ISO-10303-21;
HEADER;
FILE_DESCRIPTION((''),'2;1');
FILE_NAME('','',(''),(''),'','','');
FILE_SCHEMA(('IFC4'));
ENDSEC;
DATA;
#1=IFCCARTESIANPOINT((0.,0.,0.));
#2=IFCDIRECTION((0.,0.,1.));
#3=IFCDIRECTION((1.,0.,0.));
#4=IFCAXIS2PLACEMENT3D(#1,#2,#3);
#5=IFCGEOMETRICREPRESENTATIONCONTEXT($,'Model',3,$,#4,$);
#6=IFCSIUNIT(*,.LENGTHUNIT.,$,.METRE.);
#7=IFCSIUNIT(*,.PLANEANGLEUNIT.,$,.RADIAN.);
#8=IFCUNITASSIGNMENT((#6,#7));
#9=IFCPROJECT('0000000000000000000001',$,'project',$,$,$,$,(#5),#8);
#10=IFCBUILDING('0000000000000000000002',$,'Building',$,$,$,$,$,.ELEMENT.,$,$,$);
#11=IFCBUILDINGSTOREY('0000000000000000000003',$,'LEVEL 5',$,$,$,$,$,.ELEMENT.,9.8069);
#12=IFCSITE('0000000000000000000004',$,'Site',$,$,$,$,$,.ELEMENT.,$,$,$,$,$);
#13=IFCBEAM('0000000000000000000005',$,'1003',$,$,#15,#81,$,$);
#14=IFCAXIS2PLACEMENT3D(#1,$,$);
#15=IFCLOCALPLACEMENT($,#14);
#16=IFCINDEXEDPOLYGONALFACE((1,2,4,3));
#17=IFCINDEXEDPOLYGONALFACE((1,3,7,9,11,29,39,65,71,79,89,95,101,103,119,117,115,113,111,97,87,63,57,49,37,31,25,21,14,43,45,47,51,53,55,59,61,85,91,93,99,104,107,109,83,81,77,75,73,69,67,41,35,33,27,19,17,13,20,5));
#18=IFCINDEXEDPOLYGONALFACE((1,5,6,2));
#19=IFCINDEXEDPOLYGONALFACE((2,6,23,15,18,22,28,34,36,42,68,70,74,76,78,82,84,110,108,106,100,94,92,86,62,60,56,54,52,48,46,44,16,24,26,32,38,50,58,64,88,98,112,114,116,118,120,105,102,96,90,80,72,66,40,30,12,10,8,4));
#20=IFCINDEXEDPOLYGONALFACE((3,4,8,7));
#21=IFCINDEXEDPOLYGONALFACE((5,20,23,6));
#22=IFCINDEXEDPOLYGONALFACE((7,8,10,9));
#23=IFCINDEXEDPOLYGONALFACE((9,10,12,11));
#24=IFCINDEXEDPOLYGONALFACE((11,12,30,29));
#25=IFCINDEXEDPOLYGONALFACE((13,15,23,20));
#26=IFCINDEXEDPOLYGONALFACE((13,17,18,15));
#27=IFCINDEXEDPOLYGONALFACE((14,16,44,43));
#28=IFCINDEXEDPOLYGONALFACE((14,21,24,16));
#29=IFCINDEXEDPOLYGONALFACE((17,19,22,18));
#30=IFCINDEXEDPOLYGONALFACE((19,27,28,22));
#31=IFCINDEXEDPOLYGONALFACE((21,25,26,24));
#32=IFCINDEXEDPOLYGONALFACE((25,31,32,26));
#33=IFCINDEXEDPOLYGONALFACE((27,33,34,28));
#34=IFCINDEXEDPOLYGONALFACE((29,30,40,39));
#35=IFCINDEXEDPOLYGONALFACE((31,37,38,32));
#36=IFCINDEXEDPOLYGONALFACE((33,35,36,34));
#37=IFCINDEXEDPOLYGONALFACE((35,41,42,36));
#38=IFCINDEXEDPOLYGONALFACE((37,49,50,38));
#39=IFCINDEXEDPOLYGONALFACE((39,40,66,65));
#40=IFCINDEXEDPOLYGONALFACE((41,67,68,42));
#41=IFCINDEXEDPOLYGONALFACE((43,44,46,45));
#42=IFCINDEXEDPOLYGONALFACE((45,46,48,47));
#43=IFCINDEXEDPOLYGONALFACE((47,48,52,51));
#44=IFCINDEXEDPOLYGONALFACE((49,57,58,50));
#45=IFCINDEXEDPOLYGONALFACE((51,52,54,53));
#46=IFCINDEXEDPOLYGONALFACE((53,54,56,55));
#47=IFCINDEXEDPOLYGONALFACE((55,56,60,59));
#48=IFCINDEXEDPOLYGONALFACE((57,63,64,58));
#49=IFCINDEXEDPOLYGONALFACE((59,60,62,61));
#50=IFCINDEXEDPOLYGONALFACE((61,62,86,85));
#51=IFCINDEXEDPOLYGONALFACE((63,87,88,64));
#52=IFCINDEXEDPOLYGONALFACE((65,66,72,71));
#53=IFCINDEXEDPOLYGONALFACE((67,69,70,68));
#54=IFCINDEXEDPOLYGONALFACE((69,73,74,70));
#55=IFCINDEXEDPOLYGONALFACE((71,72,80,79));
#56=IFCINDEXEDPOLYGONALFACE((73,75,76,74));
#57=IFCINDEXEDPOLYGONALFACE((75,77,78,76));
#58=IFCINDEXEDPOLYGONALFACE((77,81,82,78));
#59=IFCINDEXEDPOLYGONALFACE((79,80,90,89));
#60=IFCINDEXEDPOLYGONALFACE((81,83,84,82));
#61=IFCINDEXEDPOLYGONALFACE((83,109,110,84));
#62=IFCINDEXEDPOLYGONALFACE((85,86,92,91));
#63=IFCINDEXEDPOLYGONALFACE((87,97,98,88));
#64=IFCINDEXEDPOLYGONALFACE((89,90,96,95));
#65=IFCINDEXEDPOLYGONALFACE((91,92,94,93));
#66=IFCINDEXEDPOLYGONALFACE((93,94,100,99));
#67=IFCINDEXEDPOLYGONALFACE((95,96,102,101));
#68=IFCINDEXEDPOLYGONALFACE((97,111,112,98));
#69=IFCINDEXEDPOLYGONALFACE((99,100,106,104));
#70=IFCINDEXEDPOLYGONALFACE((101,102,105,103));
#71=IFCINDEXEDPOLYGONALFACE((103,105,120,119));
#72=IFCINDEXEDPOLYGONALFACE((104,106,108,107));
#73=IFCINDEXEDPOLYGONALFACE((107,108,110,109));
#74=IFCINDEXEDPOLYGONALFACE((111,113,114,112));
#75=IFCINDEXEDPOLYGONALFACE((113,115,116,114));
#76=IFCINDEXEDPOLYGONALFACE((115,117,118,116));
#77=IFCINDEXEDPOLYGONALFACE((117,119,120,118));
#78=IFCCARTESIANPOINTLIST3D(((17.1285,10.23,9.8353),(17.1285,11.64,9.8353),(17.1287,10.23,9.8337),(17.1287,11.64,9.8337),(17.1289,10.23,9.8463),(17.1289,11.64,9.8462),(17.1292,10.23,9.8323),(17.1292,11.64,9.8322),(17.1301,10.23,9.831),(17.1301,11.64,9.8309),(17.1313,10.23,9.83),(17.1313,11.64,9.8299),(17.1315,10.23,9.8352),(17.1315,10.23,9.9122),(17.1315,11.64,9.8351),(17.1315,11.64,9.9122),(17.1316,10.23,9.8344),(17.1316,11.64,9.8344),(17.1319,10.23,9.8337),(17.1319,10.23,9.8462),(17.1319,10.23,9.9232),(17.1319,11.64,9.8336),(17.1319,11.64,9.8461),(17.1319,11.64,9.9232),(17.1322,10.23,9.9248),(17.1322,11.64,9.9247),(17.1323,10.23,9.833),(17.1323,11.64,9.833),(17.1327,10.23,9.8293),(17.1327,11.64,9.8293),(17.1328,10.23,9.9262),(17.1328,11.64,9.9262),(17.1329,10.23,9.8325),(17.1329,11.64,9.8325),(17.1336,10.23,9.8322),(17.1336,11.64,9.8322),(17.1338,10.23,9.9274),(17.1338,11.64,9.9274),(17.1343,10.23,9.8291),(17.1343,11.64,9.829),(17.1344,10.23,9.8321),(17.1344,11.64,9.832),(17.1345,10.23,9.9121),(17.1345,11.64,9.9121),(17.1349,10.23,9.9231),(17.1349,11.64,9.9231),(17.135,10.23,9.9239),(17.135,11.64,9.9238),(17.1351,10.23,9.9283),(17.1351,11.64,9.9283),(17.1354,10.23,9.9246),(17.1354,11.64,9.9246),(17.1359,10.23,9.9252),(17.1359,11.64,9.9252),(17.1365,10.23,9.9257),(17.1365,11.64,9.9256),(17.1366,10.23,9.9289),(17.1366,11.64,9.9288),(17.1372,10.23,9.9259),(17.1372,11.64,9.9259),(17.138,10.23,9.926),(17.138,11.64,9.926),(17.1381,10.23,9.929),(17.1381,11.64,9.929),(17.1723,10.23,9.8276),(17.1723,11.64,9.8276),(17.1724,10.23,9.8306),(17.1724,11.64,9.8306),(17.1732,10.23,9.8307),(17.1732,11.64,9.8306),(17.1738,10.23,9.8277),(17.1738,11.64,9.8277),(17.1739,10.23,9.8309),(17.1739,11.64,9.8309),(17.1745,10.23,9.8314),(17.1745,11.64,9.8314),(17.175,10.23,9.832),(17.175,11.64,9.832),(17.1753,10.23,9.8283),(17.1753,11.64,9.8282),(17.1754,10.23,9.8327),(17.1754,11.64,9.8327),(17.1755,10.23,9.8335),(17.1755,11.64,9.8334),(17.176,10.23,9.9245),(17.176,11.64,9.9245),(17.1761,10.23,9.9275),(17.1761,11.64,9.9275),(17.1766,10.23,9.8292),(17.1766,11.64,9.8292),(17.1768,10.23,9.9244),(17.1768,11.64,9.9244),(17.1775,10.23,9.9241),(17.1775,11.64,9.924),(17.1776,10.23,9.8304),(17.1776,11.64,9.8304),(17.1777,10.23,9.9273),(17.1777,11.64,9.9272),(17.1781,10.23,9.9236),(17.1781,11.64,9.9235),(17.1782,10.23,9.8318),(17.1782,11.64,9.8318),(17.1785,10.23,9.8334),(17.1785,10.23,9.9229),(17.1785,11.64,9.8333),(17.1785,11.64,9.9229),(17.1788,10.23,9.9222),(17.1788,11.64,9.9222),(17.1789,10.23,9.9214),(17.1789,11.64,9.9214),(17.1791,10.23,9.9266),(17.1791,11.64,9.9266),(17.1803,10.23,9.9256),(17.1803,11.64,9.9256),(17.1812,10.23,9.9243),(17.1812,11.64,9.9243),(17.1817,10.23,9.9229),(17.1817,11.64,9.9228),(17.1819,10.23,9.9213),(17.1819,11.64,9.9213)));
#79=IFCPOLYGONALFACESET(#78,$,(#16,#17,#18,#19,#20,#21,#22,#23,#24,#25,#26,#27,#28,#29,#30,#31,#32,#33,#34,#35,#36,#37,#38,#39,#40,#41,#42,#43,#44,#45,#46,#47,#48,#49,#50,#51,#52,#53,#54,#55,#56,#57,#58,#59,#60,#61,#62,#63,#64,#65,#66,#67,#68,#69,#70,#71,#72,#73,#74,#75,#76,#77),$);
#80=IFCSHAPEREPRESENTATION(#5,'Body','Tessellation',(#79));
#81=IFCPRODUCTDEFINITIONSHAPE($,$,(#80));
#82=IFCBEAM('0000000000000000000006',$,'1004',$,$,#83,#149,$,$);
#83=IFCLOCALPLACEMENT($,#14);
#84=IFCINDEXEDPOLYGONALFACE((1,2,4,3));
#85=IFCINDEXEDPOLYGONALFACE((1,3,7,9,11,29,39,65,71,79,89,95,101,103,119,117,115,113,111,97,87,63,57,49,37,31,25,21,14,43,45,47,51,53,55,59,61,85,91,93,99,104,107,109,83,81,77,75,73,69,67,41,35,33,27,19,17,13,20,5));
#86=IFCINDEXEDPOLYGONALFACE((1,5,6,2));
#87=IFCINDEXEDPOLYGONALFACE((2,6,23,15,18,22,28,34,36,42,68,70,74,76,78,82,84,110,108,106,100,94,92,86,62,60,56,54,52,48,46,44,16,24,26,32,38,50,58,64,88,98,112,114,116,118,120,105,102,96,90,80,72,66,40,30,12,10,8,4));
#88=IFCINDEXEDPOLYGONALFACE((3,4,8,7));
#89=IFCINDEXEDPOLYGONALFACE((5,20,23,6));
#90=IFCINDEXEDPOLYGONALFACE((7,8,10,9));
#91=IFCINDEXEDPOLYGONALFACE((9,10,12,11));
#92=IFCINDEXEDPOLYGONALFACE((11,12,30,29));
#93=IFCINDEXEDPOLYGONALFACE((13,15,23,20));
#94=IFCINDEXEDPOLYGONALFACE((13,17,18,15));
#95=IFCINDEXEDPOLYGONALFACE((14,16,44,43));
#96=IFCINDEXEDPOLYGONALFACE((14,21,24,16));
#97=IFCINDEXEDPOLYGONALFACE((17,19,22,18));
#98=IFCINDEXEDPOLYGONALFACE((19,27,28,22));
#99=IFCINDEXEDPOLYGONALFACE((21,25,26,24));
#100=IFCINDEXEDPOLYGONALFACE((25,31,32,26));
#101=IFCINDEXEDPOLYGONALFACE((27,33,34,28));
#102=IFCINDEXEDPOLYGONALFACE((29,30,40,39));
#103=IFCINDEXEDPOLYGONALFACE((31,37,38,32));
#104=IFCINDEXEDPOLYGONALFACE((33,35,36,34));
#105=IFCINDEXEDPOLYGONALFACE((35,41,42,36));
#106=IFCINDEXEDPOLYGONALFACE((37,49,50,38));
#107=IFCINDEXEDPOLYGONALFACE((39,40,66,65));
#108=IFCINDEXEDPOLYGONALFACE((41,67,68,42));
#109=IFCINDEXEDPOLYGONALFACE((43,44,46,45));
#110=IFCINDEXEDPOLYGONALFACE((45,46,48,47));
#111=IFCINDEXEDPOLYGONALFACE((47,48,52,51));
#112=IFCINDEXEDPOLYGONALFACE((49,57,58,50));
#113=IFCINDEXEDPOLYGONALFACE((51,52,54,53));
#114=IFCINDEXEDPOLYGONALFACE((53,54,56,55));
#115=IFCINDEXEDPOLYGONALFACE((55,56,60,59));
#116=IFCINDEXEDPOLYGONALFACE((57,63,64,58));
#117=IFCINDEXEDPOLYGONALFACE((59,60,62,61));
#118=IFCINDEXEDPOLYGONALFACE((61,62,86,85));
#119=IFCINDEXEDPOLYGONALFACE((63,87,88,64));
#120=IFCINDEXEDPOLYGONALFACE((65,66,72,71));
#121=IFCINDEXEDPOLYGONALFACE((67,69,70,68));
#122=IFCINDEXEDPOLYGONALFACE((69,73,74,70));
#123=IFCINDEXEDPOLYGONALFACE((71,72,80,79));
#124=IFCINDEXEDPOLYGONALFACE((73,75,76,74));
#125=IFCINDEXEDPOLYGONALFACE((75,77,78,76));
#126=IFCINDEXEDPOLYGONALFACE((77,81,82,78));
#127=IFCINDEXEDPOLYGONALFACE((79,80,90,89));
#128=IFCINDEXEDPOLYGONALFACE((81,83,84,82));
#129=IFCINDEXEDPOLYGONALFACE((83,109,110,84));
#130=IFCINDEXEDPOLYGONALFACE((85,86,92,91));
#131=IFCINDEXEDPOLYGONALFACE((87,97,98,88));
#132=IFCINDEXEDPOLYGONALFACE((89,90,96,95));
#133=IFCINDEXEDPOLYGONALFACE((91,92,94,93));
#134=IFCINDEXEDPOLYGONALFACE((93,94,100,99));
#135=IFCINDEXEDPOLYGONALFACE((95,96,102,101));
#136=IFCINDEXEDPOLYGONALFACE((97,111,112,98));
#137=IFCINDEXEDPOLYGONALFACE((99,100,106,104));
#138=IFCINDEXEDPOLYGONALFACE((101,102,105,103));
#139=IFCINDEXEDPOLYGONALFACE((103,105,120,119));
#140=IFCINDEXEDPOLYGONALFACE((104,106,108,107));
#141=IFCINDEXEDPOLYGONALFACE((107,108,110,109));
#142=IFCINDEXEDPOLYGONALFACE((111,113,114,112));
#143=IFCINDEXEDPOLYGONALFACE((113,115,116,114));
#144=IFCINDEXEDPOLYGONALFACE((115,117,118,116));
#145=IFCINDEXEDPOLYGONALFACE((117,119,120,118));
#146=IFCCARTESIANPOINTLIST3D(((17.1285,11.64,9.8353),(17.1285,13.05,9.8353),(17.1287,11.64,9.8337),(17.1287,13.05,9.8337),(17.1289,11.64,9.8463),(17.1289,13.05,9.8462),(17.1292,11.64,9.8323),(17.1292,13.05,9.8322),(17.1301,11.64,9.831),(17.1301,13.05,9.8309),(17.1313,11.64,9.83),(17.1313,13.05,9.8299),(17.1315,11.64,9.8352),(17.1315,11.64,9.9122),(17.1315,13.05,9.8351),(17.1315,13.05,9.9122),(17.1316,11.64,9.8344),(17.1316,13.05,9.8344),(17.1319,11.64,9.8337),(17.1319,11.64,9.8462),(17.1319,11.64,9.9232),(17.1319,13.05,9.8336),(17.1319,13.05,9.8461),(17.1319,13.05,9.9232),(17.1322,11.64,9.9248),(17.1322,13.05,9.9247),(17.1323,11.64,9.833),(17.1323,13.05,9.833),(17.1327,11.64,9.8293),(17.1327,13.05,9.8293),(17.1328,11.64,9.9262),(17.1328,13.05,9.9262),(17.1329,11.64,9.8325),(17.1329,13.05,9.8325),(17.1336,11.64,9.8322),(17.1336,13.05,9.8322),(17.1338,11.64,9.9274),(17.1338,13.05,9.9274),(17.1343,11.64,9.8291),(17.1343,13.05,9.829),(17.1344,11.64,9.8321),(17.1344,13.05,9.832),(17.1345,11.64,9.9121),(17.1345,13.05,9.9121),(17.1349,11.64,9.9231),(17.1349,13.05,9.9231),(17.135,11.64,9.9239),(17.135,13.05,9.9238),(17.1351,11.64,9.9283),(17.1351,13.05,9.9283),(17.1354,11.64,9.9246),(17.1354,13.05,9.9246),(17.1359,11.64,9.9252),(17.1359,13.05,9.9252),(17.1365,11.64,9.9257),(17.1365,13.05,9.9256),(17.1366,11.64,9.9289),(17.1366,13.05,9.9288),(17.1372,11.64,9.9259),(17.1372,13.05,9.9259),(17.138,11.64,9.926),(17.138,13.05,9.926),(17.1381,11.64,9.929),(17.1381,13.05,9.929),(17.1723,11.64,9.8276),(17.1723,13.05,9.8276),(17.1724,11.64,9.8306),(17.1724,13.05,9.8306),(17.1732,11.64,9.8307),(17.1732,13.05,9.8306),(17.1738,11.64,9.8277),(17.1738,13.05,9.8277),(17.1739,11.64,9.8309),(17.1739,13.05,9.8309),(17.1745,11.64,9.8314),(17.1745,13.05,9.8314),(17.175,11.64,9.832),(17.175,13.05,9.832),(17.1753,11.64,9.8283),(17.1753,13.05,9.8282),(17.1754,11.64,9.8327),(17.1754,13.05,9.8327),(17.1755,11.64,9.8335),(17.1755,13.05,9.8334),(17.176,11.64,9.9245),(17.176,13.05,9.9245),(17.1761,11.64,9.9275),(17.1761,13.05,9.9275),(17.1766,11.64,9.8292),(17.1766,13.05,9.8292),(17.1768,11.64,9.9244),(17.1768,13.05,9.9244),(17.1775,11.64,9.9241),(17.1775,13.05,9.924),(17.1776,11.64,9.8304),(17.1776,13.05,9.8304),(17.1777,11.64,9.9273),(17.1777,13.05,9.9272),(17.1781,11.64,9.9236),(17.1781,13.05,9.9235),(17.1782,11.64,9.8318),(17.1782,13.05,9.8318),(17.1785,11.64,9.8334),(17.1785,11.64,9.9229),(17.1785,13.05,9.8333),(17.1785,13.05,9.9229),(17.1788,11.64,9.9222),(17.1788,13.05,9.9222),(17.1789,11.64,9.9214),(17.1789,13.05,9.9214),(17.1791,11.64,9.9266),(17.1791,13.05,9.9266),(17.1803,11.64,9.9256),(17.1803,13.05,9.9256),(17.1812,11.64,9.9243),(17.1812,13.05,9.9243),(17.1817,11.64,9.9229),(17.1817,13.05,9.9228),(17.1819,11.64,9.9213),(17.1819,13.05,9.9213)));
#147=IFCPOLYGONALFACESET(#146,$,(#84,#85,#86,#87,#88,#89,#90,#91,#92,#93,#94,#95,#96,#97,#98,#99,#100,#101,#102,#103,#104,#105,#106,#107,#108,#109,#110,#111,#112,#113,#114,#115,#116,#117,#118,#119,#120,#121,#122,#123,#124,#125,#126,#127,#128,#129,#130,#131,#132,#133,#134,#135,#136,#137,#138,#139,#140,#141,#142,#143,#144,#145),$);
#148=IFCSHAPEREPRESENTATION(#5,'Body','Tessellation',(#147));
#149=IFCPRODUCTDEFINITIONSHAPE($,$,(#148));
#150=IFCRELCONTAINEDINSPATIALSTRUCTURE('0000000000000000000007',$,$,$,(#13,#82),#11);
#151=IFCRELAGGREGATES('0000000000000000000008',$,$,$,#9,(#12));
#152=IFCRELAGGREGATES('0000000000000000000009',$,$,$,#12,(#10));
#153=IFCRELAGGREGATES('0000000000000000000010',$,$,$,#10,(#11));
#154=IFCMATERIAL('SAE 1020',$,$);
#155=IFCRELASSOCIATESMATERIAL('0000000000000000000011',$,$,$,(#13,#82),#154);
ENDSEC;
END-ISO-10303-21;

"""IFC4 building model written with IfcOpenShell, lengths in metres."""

from ifc_helpers import new_model, si_unit, frame, origin_with_axes, origin_2d_with_axis, place, context, project, spatial, c_section, extrude, material, material_profile, profile_set, profile_usage, element, save


model = new_model("IFC4")

# Units and contexts
model_context = context("Model", 3, world=origin_with_axes())
ifc_project = project(units=[si_unit("LENGTHUNIT", "METRE"), si_unit("PLANEANGLEUNIT", "RADIAN")], contexts=[model_context])

# Site, building, storey
site = spatial("IfcSite", under=ifc_project, Name="Site", CompositionType="ELEMENT")
building = spatial("IfcBuilding", under=site, Name="Building", CompositionType="ELEMENT")
storey = spatial("IfcBuildingStorey", under=building, Name="LEVEL 5", CompositionType="ELEMENT", Elevation=9.8069)

# Beams
ifc_material = material(Name="SAE 1020")
ifc_material_profile_1 = material_profile(ifc_material, c_section(Depth=0.1, Width=0.05, WallThickness=0.003, Girth=0.017, InternalFilletRadius=0.003, at=origin_2d_with_axis()))
ifc_profile_set_1 = profile_set([ifc_material_profile_1])
ifc_profile_usage_1 = profile_usage(ifc_profile_set_1, cardinal=10)
beam_1_placement = place(None, frame((17.1552, 10.23, 9.8783), z_axis=(0.0, 1.0, -0.00003), x_axis=(-0.999256, 0.000001, 0.038562)))
element("IfcBeam", 1, at=beam_1_placement, inside=storey, material=ifc_profile_usage_1, Name="1003", context=model_context, shape_type="SweptSolid", body=[
    extrude(c_section(Depth=0.1, Width=0.05, WallThickness=0.003, Girth=0.017, InternalFilletRadius=0.003, at=origin_2d_with_axis()), origin_with_axes(), (0.0, 0.0, 1.0), 1.41),
])
ifc_material_profile_2 = material_profile(ifc_material, c_section(Depth=0.1, Width=0.05, WallThickness=0.003, Girth=0.017, InternalFilletRadius=0.003, at=origin_2d_with_axis()))
ifc_profile_set_2 = profile_set([ifc_material_profile_2])
ifc_profile_usage_2 = profile_usage(ifc_profile_set_2, cardinal=10)
beam_2_placement = place(None, frame((17.1552, 11.64, 9.8783), z_axis=(0.0, 1.0, -0.00003), x_axis=(-0.999256, 0.000001, 0.038562)))
element("IfcBeam", 2, at=beam_2_placement, inside=storey, material=ifc_profile_usage_2, Name="1004", context=model_context, shape_type="SweptSolid", body=[
    extrude(c_section(Depth=0.1, Width=0.05, WallThickness=0.003, Girth=0.017, InternalFilletRadius=0.003, at=origin_2d_with_axis()), origin_with_axes(), (0.0, 0.0, 1.0), 1.41),
])

save(model, "model.ifc")
